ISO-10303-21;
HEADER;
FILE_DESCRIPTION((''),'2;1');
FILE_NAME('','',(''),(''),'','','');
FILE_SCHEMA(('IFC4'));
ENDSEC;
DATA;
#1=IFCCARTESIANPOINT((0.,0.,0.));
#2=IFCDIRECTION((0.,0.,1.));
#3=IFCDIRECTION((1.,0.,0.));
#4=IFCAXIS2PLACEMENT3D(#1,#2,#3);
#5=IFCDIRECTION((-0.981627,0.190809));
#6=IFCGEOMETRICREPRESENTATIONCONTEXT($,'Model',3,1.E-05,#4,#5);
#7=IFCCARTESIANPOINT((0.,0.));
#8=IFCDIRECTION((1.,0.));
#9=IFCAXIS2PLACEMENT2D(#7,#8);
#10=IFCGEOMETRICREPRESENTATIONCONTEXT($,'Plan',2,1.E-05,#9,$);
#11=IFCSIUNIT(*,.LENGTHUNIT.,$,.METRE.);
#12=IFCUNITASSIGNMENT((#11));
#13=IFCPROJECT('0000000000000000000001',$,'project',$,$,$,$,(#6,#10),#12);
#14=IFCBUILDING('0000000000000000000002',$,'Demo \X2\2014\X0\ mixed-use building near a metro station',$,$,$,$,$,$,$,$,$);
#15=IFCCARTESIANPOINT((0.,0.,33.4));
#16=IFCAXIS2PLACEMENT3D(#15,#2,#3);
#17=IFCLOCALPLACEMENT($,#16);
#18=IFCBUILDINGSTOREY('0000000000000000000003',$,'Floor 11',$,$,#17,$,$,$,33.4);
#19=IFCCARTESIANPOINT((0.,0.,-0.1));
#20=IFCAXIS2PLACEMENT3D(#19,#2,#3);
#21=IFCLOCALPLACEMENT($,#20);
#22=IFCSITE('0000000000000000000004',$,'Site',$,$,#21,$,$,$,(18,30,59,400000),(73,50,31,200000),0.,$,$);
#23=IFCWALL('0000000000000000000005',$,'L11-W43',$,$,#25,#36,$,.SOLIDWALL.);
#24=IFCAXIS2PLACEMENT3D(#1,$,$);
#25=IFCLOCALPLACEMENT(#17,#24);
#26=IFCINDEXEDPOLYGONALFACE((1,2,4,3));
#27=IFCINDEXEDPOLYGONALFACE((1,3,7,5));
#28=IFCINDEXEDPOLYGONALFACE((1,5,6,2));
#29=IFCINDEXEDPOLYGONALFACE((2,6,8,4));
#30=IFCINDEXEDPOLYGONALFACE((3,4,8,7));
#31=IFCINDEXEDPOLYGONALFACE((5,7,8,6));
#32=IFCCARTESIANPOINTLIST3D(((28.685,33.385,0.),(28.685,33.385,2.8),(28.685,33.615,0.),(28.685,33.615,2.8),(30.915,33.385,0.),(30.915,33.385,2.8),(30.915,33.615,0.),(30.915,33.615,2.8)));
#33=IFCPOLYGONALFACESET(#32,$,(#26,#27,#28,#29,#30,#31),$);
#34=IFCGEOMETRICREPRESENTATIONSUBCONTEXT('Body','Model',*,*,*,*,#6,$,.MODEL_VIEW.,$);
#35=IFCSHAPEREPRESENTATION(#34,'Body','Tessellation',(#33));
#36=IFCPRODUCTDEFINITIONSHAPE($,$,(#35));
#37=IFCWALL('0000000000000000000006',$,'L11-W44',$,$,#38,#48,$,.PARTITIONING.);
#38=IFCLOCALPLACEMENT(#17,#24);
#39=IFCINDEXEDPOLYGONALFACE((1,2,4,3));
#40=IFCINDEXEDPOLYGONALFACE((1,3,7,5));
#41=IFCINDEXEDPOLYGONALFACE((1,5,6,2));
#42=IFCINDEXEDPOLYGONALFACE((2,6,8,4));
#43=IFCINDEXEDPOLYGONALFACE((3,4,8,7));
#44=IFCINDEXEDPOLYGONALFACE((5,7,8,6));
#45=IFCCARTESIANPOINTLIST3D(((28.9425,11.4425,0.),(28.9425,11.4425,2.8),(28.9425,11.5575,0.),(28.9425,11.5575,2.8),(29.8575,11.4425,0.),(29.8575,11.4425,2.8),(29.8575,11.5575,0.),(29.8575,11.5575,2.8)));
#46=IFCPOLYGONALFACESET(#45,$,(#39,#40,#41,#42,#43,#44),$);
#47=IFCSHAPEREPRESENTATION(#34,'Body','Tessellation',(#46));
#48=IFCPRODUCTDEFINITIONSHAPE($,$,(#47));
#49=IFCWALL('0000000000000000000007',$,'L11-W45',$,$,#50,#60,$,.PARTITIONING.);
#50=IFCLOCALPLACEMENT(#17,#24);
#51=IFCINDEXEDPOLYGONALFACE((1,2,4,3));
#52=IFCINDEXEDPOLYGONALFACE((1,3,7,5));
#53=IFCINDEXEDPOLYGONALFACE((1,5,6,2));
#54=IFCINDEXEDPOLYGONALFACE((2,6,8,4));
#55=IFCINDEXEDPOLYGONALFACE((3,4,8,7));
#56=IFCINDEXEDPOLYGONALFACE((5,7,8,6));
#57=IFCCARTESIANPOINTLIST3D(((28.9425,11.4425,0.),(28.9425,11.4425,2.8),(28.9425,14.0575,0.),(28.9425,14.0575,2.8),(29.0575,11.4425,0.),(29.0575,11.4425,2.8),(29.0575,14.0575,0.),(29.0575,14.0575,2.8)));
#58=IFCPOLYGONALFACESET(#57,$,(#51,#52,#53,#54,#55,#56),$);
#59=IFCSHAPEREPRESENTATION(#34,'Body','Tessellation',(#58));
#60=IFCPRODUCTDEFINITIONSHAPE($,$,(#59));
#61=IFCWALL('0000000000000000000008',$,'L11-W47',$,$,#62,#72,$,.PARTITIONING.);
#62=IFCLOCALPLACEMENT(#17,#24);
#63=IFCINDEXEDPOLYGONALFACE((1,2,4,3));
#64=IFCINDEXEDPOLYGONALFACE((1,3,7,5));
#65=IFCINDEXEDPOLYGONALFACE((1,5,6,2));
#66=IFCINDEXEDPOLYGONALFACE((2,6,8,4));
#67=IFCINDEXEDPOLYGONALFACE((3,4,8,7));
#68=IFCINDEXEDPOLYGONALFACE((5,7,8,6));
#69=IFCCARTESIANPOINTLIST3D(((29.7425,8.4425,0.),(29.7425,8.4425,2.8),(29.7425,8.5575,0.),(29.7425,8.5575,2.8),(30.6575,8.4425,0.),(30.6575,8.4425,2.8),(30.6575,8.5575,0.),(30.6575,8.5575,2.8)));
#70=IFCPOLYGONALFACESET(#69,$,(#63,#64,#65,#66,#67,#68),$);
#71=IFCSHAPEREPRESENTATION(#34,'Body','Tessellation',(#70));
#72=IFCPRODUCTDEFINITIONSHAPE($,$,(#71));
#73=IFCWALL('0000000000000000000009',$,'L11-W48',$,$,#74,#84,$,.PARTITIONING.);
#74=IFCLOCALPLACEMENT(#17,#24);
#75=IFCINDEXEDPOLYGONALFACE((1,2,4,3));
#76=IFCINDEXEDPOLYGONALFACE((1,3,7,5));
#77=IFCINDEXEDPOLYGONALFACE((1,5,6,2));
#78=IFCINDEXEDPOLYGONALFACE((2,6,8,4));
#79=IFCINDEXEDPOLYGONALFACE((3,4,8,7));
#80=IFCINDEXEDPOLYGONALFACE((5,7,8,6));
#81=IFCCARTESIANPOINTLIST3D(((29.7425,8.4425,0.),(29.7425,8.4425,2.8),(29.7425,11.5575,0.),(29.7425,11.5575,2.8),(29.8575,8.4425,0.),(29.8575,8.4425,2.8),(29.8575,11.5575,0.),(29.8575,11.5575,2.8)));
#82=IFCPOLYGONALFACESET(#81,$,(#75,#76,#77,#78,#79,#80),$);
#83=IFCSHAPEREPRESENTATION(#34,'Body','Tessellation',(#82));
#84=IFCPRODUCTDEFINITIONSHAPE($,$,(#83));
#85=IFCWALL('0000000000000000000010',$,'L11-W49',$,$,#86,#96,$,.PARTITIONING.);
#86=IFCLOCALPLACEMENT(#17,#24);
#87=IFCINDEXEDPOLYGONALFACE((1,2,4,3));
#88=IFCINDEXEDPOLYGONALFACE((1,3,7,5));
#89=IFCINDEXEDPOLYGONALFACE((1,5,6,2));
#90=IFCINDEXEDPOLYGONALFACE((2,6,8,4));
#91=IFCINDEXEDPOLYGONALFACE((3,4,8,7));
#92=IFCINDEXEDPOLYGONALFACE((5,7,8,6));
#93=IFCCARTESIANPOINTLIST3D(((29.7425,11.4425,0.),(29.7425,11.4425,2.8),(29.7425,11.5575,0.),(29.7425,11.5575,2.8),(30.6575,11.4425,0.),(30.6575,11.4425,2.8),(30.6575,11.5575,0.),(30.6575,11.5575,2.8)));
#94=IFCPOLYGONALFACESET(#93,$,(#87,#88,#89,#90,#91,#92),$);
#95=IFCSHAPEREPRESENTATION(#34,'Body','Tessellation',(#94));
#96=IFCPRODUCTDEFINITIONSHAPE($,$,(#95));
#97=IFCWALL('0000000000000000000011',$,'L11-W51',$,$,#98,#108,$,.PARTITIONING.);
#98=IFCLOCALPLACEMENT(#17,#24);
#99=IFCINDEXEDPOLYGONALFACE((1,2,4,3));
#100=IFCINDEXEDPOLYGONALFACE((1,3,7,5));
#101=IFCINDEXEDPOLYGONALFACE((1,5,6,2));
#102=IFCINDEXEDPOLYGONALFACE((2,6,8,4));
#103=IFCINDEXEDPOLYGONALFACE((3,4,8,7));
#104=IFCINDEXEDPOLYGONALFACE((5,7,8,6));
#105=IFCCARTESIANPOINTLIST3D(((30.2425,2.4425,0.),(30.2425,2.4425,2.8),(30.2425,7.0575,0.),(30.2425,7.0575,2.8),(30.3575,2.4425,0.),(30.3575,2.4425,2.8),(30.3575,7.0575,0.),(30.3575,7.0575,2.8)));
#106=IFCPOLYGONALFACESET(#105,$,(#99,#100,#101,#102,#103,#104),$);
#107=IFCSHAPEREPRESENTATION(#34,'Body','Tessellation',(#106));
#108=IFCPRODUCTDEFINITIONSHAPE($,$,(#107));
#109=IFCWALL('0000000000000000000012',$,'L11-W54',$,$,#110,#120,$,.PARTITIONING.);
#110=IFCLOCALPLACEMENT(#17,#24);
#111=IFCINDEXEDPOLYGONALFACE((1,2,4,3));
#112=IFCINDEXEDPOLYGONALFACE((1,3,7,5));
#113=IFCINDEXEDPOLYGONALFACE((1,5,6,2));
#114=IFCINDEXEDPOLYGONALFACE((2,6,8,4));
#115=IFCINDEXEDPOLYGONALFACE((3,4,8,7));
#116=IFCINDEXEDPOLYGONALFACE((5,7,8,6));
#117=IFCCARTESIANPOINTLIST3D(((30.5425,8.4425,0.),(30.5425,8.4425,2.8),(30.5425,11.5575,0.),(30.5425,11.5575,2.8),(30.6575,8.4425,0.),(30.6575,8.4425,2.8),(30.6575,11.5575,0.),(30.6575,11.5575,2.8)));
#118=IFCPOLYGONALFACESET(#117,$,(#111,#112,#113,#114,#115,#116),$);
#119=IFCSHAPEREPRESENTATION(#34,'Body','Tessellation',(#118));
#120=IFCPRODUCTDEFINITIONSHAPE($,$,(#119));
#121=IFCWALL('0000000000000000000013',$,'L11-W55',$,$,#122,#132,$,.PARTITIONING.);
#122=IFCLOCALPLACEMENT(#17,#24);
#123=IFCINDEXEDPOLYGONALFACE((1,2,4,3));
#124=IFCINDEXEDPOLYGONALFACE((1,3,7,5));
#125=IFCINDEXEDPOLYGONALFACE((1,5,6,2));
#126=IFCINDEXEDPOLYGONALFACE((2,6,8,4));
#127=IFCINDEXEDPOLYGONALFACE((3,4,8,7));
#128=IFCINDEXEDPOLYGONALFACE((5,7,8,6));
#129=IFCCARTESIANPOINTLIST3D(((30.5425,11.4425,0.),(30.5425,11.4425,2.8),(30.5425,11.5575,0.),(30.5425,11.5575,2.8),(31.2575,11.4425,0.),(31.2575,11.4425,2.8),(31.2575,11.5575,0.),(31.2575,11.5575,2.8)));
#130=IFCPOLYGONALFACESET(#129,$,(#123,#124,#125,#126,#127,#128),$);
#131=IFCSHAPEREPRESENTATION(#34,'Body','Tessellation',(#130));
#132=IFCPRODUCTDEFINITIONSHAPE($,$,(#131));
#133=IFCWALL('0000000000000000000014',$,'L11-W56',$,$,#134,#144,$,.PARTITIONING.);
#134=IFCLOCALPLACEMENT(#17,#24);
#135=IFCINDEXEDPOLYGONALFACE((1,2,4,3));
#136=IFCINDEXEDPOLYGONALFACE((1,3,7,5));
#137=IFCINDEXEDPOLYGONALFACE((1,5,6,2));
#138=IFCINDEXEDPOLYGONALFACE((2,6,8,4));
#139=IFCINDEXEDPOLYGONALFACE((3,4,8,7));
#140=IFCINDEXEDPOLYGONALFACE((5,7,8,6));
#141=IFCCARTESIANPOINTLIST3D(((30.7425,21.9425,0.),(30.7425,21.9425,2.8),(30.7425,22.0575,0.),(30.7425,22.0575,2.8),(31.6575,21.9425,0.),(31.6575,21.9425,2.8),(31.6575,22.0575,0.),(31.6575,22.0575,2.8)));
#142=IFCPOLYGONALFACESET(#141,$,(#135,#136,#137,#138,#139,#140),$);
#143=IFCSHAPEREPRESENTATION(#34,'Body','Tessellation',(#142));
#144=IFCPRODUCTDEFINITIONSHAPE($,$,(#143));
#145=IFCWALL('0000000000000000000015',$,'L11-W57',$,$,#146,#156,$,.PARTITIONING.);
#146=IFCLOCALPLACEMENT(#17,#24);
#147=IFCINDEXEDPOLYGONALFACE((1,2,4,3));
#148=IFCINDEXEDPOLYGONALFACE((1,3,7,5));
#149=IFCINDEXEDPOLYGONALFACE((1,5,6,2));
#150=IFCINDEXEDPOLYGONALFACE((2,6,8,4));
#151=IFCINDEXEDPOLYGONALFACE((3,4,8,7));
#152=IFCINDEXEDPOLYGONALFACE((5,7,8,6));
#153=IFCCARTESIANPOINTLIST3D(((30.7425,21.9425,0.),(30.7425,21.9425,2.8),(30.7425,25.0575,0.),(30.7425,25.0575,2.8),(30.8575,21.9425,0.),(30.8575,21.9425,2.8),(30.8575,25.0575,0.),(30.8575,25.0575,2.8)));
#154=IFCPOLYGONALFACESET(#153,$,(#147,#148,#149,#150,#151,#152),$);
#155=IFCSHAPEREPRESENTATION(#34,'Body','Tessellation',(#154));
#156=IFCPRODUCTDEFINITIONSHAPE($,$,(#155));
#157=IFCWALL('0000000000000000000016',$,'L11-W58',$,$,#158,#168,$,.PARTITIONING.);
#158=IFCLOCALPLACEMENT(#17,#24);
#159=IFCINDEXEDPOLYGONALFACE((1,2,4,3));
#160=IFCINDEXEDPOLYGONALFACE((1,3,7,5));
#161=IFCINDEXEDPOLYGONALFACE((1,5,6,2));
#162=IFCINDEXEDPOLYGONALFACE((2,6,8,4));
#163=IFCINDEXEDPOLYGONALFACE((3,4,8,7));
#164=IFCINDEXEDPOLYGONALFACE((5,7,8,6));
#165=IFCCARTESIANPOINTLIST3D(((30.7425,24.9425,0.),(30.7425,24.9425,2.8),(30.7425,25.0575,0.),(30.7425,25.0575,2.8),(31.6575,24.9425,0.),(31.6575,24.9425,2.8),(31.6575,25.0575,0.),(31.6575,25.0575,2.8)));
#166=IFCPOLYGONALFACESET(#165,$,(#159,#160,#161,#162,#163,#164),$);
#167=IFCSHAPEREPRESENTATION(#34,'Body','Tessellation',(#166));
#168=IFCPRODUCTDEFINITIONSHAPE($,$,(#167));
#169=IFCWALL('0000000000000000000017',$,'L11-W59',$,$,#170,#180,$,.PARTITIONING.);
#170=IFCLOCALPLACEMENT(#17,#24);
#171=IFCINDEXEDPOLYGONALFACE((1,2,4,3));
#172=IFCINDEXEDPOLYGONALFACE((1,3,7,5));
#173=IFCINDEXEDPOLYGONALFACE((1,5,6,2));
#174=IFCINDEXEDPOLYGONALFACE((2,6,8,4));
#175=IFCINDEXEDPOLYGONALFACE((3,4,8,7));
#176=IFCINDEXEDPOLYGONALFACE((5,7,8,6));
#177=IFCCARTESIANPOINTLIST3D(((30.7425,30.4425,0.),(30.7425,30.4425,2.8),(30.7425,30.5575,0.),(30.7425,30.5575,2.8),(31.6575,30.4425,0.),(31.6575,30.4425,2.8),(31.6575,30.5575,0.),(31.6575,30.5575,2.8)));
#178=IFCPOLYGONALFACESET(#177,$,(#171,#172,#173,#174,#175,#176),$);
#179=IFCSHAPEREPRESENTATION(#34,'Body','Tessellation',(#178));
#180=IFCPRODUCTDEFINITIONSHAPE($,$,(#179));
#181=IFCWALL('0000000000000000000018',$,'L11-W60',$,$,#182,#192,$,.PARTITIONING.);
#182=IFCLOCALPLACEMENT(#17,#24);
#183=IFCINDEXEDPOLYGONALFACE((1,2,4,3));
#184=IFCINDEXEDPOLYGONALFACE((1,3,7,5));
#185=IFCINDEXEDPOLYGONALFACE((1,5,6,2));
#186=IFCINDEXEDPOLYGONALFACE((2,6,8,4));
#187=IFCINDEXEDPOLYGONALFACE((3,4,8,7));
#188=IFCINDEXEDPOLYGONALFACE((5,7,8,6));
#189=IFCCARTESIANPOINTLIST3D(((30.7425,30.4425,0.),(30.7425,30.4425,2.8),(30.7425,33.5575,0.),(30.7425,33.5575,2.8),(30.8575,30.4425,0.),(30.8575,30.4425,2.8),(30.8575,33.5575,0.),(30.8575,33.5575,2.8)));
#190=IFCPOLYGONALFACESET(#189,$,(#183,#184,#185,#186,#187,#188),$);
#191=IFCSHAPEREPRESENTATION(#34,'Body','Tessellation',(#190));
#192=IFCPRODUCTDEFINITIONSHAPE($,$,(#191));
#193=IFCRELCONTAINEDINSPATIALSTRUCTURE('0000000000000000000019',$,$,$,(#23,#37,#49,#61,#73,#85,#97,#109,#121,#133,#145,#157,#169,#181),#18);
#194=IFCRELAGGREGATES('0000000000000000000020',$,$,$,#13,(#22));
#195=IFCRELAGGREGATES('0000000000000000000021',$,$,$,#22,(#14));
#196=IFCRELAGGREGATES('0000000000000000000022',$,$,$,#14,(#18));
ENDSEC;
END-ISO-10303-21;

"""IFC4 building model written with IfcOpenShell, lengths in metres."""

from ifc_helpers import new_model, si_unit, direction, frame, origin_with_axes, origin_2d_with_axis, place, context, subcontext, project, spatial, line, indexed_curve, outline, extrude, element, save


model = new_model("IFC4")

# Units and contexts
model_context = context("Model", 3, precision=1e-05, world=origin_with_axes(), true_north=direction((-0.981627, 0.190809)))
plan_context = context("Plan", 2, precision=1e-05, world=origin_2d_with_axis())
body_context = subcontext(model_context, "Body", "Model", "MODEL_VIEW")
ifc_project = project(units=[si_unit("LENGTHUNIT", "METRE")], contexts=[model_context, plan_context])

# Site, building, storey
site_placement = place(None, frame((0.0, 0.0, -0.1), z_axis=(0.0, 0.0, 1.0), x_axis=(1.0, 0.0, 0.0)))
site = spatial("IfcSite", under=ifc_project, at=site_placement, Name="Site", RefLatitude=(18, 30, 59, 400000), RefLongitude=(73, 50, 31, 200000), RefElevation=0.0)
building = spatial("IfcBuilding", under=site, Name="Demo — mixed-use building near a metro station")
storey_placement = place(None, frame((0.0, 0.0, 33.4), z_axis=(0.0, 0.0, 1.0), x_axis=(1.0, 0.0, 0.0)))
storey = spatial("IfcBuildingStorey", under=building, at=storey_placement, Name="Floor 11", Elevation=33.4)

# Walls
wall_1_placement = place(storey_placement, frame((0.0, 0.0, -33.4), z_axis=(0.0, 0.0, 1.0), x_axis=(1.0, 0.0, 0.0)))
element("IfcWall", 1, at=wall_1_placement, inside=storey, Name="L11-W43", PredefinedType="SOLIDWALL", context=body_context, shape_type="SweptSolid", body=[
    extrude(outline(indexed_curve([(30.915, 33.385), (28.685, 33.385), (28.685, 33.615), (30.915, 33.615)], segments=[line(1, 2, 3, 4, 1)])), frame((0.0, 0.0, 33.4), z_axis=(0.0, 0.0, 1.0), x_axis=(1.0, 0.0, 0.0)), (0.0, 0.0, 1.0), 2.8),
])
wall_2_placement = place(storey_placement, frame((0.0, 0.0, -33.4), z_axis=(0.0, 0.0, 1.0), x_axis=(1.0, 0.0, 0.0)))
element("IfcWall", 2, at=wall_2_placement, inside=storey, Name="L11-W44", PredefinedType="PARTITIONING", context=body_context, shape_type="SweptSolid", body=[
    extrude(outline(indexed_curve([(28.9425, 11.5575), (29.8575, 11.5575), (29.8575, 11.4425), (28.9425, 11.4425)], segments=[line(1, 2, 3, 4, 1)])), frame((0.0, 0.0, 33.4), z_axis=(0.0, 0.0, 1.0), x_axis=(1.0, 0.0, 0.0)), (0.0, 0.0, 1.0), 2.8),
])
wall_3_placement = place(storey_placement, frame((0.0, 0.0, -33.4), z_axis=(0.0, 0.0, 1.0), x_axis=(1.0, 0.0, 0.0)))
element("IfcWall", 3, at=wall_3_placement, inside=storey, Name="L11-W45", PredefinedType="PARTITIONING", context=body_context, shape_type="SweptSolid", body=[
    extrude(outline(indexed_curve([(28.9425, 11.4425), (28.9425, 14.0575), (29.0575, 14.0575), (29.0575, 11.4425)], segments=[line(1, 2, 3, 4, 1)])), frame((0.0, 0.0, 33.4), z_axis=(0.0, 0.0, 1.0), x_axis=(1.0, 0.0, 0.0)), (0.0, 0.0, 1.0), 2.8),
])

# Walls
wall_4_placement = place(storey_placement, frame((0.0, 0.0, -33.4), z_axis=(0.0, 0.0, 1.0), x_axis=(1.0, 0.0, 0.0)))
element("IfcWall", 4, at=wall_4_placement, inside=storey, Name="L11-W47", PredefinedType="PARTITIONING", context=body_context, shape_type="SweptSolid", body=[
    extrude(outline(indexed_curve([(30.6575, 8.4425), (29.7425, 8.4425), (29.7425, 8.5575), (30.6575, 8.5575)], segments=[line(1, 2, 3, 4, 1)])), frame((0.0, 0.0, 33.4), z_axis=(0.0, 0.0, 1.0), x_axis=(1.0, 0.0, 0.0)), (0.0, 0.0, 1.0), 2.8),
])
wall_5_placement = place(storey_placement, frame((0.0, 0.0, -33.4), z_axis=(0.0, 0.0, 1.0), x_axis=(1.0, 0.0, 0.0)))
element("IfcWall", 5, at=wall_5_placement, inside=storey, Name="L11-W48", PredefinedType="PARTITIONING", context=body_context, shape_type="SweptSolid", body=[
    extrude(outline(indexed_curve([(29.7425, 8.4425), (29.7425, 11.5575), (29.8575, 11.5575), (29.8575, 8.4425)], segments=[line(1, 2, 3, 4, 1)])), frame((0.0, 0.0, 33.4), z_axis=(0.0, 0.0, 1.0), x_axis=(1.0, 0.0, 0.0)), (0.0, 0.0, 1.0), 2.8),
])
wall_6_placement = place(storey_placement, frame((0.0, 0.0, -33.4), z_axis=(0.0, 0.0, 1.0), x_axis=(1.0, 0.0, 0.0)))
element("IfcWall", 6, at=wall_6_placement, inside=storey, Name="L11-W49", PredefinedType="PARTITIONING", context=body_context, shape_type="SweptSolid", body=[
    extrude(outline(indexed_curve([(29.7425, 11.5575), (30.6575, 11.5575), (30.6575, 11.4425), (29.7425, 11.4425)], segments=[line(1, 2, 3, 4, 1)])), frame((0.0, 0.0, 33.4), z_axis=(0.0, 0.0, 1.0), x_axis=(1.0, 0.0, 0.0)), (0.0, 0.0, 1.0), 2.8),
])

# Wall
wall_7_placement = place(storey_placement, frame((0.0, 0.0, -33.4), z_axis=(0.0, 0.0, 1.0), x_axis=(1.0, 0.0, 0.0)))
element("IfcWall", 7, at=wall_7_placement, inside=storey, Name="L11-W51", PredefinedType="PARTITIONING", context=body_context, shape_type="SweptSolid", body=[
    extrude(outline(indexed_curve([(30.2425, 2.4425), (30.2425, 7.0575), (30.3575, 7.0575), (30.3575, 2.4425)], segments=[line(1, 2, 3, 4, 1)])), frame((0.0, 0.0, 33.4), z_axis=(0.0, 0.0, 1.0), x_axis=(1.0, 0.0, 0.0)), (0.0, 0.0, 1.0), 2.8),
])

# Walls
wall_8_placement = place(storey_placement, frame((0.0, 0.0, -33.4), z_axis=(0.0, 0.0, 1.0), x_axis=(1.0, 0.0, 0.0)))
element("IfcWall", 8, at=wall_8_placement, inside=storey, Name="L11-W54", PredefinedType="PARTITIONING", context=body_context, shape_type="SweptSolid", body=[
    extrude(outline(indexed_curve([(30.5425, 8.4425), (30.5425, 11.5575), (30.6575, 11.5575), (30.6575, 8.4425)], segments=[line(1, 2, 3, 4, 1)])), frame((0.0, 0.0, 33.4), z_axis=(0.0, 0.0, 1.0), x_axis=(1.0, 0.0, 0.0)), (0.0, 0.0, 1.0), 2.8),
])
wall_9_placement = place(storey_placement, frame((0.0, 0.0, -33.4), z_axis=(0.0, 0.0, 1.0), x_axis=(1.0, 0.0, 0.0)))
element("IfcWall", 9, at=wall_9_placement, inside=storey, Name="L11-W55", PredefinedType="PARTITIONING", context=body_context, shape_type="SweptSolid", body=[
    extrude(outline(indexed_curve([(30.5425, 11.5575), (31.2575, 11.5575), (31.2575, 11.4425), (30.5425, 11.4425)], segments=[line(1, 2, 3, 4, 1)])), frame((0.0, 0.0, 33.4), z_axis=(0.0, 0.0, 1.0), x_axis=(1.0, 0.0, 0.0)), (0.0, 0.0, 1.0), 2.8),
])
wall_10_placement = place(storey_placement, frame((0.0, 0.0, -33.4), z_axis=(0.0, 0.0, 1.0), x_axis=(1.0, 0.0, 0.0)))
element("IfcWall", 10, at=wall_10_placement, inside=storey, Name="L11-W56", PredefinedType="PARTITIONING", context=body_context, shape_type="SweptSolid", body=[
    extrude(outline(indexed_curve([(31.6575, 21.9425), (30.7425, 21.9425), (30.7425, 22.0575), (31.6575, 22.0575)], segments=[line(1, 2, 3, 4, 1)])), frame((0.0, 0.0, 33.4), z_axis=(0.0, 0.0, 1.0), x_axis=(1.0, 0.0, 0.0)), (0.0, 0.0, 1.0), 2.8),
])
wall_11_placement = place(storey_placement, frame((0.0, 0.0, -33.4), z_axis=(0.0, 0.0, 1.0), x_axis=(1.0, 0.0, 0.0)))
element("IfcWall", 11, at=wall_11_placement, inside=storey, Name="L11-W57", PredefinedType="PARTITIONING", context=body_context, shape_type="SweptSolid", body=[
    extrude(outline(indexed_curve([(30.7425, 21.9425), (30.7425, 25.0575), (30.8575, 25.0575), (30.8575, 21.9425)], segments=[line(1, 2, 3, 4, 1)])), frame((0.0, 0.0, 33.4), z_axis=(0.0, 0.0, 1.0), x_axis=(1.0, 0.0, 0.0)), (0.0, 0.0, 1.0), 2.8),
])
wall_12_placement = place(storey_placement, frame((0.0, 0.0, -33.4), z_axis=(0.0, 0.0, 1.0), x_axis=(1.0, 0.0, 0.0)))
element("IfcWall", 12, at=wall_12_placement, inside=storey, Name="L11-W58", PredefinedType="PARTITIONING", context=body_context, shape_type="SweptSolid", body=[
    extrude(outline(indexed_curve([(31.6575, 24.9425), (30.7425, 24.9425), (30.7425, 25.0575), (31.6575, 25.0575)], segments=[line(1, 2, 3, 4, 1)])), frame((0.0, 0.0, 33.4), z_axis=(0.0, 0.0, 1.0), x_axis=(1.0, 0.0, 0.0)), (0.0, 0.0, 1.0), 2.8),
])
wall_13_placement = place(storey_placement, frame((0.0, 0.0, -33.4), z_axis=(0.0, 0.0, 1.0), x_axis=(1.0, 0.0, 0.0)))
element("IfcWall", 13, at=wall_13_placement, inside=storey, Name="L11-W59", PredefinedType="PARTITIONING", context=body_context, shape_type="SweptSolid", body=[
    extrude(outline(indexed_curve([(31.6575, 30.4425), (30.7425, 30.4425), (30.7425, 30.5575), (31.6575, 30.5575)], segments=[line(1, 2, 3, 4, 1)])), frame((0.0, 0.0, 33.4), z_axis=(0.0, 0.0, 1.0), x_axis=(1.0, 0.0, 0.0)), (0.0, 0.0, 1.0), 2.8),
])
wall_14_placement = place(storey_placement, frame((0.0, 0.0, -33.4), z_axis=(0.0, 0.0, 1.0), x_axis=(1.0, 0.0, 0.0)))
element("IfcWall", 14, at=wall_14_placement, inside=storey, Name="L11-W60", PredefinedType="PARTITIONING", context=body_context, shape_type="SweptSolid", body=[
    extrude(outline(indexed_curve([(30.7425, 30.4425), (30.7425, 33.5575), (30.8575, 33.5575), (30.8575, 30.4425)], segments=[line(1, 2, 3, 4, 1)])), frame((0.0, 0.0, 33.4), z_axis=(0.0, 0.0, 1.0), x_axis=(1.0, 0.0, 0.0)), (0.0, 0.0, 1.0), 2.8),
])

save(model, "model.ifc")
